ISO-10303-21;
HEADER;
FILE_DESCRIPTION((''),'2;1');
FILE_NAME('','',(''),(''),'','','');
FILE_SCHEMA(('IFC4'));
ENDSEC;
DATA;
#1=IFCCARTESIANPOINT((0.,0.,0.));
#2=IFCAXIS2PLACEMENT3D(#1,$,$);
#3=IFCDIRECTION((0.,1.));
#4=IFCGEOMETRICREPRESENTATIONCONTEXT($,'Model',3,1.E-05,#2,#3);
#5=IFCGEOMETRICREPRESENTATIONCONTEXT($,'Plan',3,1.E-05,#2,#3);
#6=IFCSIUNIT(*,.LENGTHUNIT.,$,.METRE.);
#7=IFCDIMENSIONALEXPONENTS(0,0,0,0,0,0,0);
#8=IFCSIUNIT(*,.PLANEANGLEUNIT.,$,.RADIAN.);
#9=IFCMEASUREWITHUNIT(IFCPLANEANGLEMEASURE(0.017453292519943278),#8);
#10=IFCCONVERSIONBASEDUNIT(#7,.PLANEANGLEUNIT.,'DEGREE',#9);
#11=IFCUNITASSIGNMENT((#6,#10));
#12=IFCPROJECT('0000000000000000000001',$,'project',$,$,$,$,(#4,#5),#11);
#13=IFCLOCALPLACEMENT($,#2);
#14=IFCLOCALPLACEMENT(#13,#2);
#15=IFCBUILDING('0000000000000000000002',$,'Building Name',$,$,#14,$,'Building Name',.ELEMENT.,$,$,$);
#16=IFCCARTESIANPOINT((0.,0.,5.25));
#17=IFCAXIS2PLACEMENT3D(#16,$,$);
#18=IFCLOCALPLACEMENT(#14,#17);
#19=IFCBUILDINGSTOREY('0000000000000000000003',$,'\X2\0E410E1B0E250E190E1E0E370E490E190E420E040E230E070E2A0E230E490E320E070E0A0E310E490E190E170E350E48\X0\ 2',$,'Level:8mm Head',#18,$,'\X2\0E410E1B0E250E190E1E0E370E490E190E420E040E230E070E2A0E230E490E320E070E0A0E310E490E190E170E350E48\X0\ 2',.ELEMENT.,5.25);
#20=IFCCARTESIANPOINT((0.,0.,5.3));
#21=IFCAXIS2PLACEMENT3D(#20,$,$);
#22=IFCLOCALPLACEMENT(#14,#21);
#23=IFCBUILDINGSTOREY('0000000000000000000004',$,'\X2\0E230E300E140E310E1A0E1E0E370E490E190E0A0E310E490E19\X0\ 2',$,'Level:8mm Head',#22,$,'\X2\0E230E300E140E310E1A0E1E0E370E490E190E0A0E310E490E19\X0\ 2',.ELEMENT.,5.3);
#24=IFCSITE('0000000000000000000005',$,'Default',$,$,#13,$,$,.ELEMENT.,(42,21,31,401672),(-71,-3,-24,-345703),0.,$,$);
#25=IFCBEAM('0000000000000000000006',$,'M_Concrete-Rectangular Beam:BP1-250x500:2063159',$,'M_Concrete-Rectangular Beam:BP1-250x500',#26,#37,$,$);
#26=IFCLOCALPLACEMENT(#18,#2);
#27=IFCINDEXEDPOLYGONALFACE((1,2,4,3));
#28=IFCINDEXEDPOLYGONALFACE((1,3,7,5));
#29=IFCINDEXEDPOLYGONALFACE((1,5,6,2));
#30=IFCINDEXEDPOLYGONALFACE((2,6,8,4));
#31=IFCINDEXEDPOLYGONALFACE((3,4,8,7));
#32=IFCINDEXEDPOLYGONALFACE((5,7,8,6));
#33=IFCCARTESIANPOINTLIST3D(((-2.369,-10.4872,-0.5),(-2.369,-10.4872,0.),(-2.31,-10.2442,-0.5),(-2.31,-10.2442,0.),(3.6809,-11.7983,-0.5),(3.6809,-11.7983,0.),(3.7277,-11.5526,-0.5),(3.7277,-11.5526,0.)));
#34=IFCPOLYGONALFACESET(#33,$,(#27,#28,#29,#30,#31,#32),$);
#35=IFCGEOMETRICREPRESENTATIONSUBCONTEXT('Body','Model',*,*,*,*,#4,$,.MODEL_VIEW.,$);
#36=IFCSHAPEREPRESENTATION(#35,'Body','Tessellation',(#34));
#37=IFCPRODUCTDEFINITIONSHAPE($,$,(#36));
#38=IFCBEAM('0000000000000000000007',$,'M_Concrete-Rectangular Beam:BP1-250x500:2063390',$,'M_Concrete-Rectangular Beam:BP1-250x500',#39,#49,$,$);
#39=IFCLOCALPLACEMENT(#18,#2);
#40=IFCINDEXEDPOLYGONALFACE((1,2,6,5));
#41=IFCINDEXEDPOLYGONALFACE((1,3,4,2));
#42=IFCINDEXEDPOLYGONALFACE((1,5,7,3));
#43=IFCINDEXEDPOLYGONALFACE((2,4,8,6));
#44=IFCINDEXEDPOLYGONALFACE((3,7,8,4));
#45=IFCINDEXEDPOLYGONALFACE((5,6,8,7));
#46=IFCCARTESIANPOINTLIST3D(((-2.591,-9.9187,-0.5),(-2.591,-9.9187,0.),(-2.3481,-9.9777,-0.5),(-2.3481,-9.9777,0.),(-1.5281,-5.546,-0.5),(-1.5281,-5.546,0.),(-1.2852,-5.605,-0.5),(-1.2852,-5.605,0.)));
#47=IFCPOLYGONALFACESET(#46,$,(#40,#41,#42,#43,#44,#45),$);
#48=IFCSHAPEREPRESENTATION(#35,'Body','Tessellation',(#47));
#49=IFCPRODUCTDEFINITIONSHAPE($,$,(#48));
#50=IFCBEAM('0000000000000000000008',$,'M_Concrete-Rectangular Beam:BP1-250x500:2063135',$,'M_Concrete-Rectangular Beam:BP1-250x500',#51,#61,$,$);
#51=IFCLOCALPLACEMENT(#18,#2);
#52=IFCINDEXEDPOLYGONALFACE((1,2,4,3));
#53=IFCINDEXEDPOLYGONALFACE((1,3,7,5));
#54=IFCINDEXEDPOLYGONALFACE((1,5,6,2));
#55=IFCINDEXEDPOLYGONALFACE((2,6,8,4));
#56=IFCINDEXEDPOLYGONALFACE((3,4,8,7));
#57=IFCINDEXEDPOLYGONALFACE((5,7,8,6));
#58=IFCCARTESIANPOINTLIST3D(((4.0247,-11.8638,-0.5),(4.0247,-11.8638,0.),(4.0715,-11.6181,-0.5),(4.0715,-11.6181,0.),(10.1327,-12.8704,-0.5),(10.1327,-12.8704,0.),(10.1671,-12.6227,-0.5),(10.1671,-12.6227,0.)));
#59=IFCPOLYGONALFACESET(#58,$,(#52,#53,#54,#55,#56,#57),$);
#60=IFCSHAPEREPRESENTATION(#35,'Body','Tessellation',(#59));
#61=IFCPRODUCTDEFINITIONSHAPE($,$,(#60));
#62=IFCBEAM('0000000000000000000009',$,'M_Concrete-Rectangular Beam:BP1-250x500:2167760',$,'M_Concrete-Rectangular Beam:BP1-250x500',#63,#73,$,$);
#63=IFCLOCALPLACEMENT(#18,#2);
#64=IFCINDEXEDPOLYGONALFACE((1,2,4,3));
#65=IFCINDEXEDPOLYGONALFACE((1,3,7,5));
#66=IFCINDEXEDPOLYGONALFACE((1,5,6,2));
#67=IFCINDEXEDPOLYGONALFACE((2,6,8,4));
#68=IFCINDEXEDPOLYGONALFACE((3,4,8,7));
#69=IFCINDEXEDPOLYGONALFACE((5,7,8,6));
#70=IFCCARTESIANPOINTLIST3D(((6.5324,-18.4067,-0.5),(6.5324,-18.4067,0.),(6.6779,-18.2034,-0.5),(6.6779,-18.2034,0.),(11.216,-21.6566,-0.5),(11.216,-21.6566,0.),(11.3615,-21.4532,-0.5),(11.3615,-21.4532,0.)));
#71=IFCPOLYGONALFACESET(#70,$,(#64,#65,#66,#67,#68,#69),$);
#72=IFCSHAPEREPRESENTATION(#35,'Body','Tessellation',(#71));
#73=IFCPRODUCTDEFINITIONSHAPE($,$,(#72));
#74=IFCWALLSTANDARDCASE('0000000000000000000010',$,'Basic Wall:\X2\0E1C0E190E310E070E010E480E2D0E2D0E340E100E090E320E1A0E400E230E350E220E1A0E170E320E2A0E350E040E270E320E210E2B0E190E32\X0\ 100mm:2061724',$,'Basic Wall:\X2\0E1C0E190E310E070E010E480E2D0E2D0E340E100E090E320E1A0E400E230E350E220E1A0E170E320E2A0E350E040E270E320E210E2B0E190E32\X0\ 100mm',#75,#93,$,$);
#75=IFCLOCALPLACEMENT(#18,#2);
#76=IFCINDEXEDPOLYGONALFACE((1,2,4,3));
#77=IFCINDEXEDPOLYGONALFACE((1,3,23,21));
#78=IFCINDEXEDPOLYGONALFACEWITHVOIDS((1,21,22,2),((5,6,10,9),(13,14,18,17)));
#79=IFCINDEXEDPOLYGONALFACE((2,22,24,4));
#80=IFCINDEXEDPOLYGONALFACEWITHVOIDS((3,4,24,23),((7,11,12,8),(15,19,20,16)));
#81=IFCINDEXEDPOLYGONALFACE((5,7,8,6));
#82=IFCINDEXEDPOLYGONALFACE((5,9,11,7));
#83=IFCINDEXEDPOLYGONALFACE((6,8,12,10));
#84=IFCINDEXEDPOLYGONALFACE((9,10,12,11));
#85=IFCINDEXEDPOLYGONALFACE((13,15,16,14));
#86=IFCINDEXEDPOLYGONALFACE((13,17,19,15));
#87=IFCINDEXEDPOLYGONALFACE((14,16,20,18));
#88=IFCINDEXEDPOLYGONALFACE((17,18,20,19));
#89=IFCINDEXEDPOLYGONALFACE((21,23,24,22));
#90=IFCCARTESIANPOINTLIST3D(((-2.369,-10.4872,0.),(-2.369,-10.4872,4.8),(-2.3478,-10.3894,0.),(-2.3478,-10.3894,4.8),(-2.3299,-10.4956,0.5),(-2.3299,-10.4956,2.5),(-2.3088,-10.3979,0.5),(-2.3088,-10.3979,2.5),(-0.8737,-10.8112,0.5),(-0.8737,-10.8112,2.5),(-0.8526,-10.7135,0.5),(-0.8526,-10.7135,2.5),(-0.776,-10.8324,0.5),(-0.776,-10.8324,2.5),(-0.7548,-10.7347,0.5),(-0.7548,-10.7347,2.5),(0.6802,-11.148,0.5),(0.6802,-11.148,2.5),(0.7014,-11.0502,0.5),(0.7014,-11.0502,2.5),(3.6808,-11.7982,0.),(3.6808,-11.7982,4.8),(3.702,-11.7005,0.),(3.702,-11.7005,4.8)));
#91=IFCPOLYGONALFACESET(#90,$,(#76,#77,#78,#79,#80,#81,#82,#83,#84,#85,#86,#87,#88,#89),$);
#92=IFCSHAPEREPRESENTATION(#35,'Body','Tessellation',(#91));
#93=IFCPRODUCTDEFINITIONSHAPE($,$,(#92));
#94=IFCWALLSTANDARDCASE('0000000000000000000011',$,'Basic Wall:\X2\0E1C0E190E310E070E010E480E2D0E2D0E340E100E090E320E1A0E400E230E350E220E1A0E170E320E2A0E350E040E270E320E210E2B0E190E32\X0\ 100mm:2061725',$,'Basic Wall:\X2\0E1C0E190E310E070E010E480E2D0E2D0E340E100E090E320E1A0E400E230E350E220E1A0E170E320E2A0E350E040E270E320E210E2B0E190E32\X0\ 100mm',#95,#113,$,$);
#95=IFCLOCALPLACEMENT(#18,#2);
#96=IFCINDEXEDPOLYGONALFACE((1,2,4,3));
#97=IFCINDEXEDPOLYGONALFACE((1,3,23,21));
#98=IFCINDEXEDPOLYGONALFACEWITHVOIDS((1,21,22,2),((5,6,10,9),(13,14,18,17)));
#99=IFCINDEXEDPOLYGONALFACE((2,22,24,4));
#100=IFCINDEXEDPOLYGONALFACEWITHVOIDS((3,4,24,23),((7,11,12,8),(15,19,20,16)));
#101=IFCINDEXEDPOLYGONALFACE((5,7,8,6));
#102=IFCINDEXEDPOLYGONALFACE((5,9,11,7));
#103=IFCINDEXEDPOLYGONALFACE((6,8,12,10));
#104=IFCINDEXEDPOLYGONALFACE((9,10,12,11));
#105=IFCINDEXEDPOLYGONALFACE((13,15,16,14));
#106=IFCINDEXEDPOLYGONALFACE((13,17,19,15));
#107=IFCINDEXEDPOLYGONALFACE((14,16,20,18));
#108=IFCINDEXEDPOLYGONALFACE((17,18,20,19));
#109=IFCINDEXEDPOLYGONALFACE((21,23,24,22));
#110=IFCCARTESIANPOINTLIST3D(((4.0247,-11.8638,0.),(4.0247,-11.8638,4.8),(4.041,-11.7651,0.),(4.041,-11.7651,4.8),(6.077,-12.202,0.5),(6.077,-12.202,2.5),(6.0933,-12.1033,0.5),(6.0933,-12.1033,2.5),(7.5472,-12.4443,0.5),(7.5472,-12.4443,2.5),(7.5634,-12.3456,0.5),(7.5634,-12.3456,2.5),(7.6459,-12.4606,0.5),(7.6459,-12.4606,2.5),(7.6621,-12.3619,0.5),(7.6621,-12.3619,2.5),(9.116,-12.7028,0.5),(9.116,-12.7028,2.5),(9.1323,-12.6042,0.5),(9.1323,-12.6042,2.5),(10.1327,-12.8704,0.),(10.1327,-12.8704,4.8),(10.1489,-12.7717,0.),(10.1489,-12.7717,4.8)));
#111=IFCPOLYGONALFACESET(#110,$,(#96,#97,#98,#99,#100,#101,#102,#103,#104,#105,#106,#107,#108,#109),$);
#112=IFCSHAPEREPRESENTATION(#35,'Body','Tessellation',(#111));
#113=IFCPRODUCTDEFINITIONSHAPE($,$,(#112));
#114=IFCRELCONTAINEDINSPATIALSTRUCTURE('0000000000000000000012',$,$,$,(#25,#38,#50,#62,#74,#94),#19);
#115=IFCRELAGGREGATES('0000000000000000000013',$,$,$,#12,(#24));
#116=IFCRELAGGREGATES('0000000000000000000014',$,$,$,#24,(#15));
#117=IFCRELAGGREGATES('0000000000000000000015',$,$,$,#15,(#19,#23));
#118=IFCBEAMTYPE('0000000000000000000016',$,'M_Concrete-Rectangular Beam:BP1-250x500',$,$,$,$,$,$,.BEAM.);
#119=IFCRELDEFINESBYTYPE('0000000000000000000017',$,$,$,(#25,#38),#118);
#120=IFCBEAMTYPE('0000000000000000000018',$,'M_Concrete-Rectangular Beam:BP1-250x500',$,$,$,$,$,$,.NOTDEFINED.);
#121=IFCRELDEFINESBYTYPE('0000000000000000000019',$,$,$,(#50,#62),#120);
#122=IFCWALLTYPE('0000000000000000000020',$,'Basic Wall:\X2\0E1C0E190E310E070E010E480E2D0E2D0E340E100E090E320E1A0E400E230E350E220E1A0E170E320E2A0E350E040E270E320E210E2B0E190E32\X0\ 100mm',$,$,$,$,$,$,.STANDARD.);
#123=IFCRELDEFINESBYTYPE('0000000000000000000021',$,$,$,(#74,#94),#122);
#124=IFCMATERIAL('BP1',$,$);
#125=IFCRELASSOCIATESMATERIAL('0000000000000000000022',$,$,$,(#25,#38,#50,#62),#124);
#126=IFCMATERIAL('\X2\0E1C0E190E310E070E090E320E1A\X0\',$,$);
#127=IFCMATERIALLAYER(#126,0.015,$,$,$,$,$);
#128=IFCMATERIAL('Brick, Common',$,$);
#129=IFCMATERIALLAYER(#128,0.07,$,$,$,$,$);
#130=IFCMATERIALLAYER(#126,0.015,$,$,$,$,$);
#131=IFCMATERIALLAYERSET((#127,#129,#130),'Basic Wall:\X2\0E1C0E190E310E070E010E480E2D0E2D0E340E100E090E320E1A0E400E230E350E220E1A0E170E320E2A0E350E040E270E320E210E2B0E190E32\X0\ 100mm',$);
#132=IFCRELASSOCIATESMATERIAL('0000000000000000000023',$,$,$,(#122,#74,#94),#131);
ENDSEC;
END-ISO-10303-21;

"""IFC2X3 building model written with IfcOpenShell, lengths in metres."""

from ifc_helpers import new_model, entity, si_unit, converted_unit, direction, frame, frame_2d, origin, place, context, subcontext, project, spatial, rectangle, extrude, clip, halfspace, material, layer, layer_set, layer_usage, type_object, element, save


model = new_model("IFC2X3")

# Units and contexts
model_context = context("Model", 3, precision=1e-05, world=origin(), true_north=direction((0.0, 1.0)))
plan_context = context("Plan", 3, precision=1e-05, world=origin(), true_north=direction((0.0, 1.0)))
body_context = subcontext(model_context, "Body", "Model", "MODEL_VIEW")
ifc_project = project(units=[si_unit("LENGTHUNIT", "METRE"), converted_unit("PLANEANGLEUNIT", "DEGREE", entity("IfcPlaneAngleMeasure", 0.017453292519943278), si_unit("PLANEANGLEUNIT", "RADIAN"), dimensions=[0, 0, 0, 0, 0, 0, 0])], contexts=[model_context, plan_context])

# Site, building, storey
site_placement = place(None, origin())
site = spatial("IfcSite", under=ifc_project, at=site_placement, Name="Default", CompositionType="ELEMENT", RefLatitude=(42, 21, 31, 401672), RefLongitude=(-71, -3, -24, -345703), RefElevation=0.0)
building_placement = place(site_placement, origin())
building = spatial("IfcBuilding", under=site, at=building_placement, Name="Building Name", LongName="Building Name", CompositionType="ELEMENT")
storey_1_placement = place(building_placement, frame((0.0, 0.0, 5.25)))
storey_1 = spatial("IfcBuildingStorey", under=building, at=storey_1_placement, Name="แปลนพื้นโครงสร้างชั้นที่ 2", ObjectType="Level:8mm Head", LongName="แปลนพื้นโครงสร้างชั้นที่ 2", CompositionType="ELEMENT", Elevation=5.25)

# Beams
ifc_material_1 = material(Name="BP1")
beam_type_1 = type_object("IfcBeamType", Name="M_Concrete-Rectangular Beam:BP1-250x500", PredefinedType="BEAM")
beam_1_placement = place(storey_1_placement, frame((3.6809, -11.7983, 0.0), z_axis=(0.0, 0.0, 1.0), x_axis=(-0.977314, 0.211795, 0.0)))
element("IfcBeam", 1, at=beam_1_placement, inside=storey_1, type_object=beam_type_1, material=ifc_material_1, Name="M_Concrete-Rectangular Beam:BP1-250x500:2063159", ObjectType="M_Concrete-Rectangular Beam:BP1-250x500", context=body_context, shape_type="Clipping", body=[
    clip(clip(extrude(rectangle(XDim=0.5, YDim=0.25, at=frame_2d((0.0, 0.0), x_axis=(1.0, 0.0))), frame((0.0, -0.125, -0.25), z_axis=(1.0, 0.0, 0.0), x_axis=(0.0, 0.0, -1.0)), (0.0, 0.0, 1.0), 6.1903), halfspace(frame((6.1903, 0.0, 0.0), z_axis=(0.999686, -0.02504, 0.0), x_axis=(0.0, 0.0, -1.0)), False)), halfspace(frame((0.0125, -0.4998, 0.0), z_axis=(-0.999686, -0.02504, 0.0), x_axis=(0.0, 0.0, -1.0)), False)),
])
beam_2_placement = place(storey_1_placement, frame((-2.591, -9.9187, 0.0), z_axis=(0.0, 0.0, 1.0), x_axis=(0.236201, 0.971704, 0.0)))
element("IfcBeam", 2, at=beam_2_placement, inside=storey_1, type_object=beam_type_1, material=ifc_material_1, Name="M_Concrete-Rectangular Beam:BP1-250x500:2063390", ObjectType="M_Concrete-Rectangular Beam:BP1-250x500", context=body_context, shape_type="SweptSolid", body=[
    extrude(rectangle(XDim=0.5, YDim=0.25, at=frame_2d((0.0, 0.0), x_axis=(1.0, 0.0))), frame((0.0, -0.125, -0.25), z_axis=(1.0, 0.0, 0.0), x_axis=(0.0, 0.0, -1.0)), (0.0, 0.0, 1.0), 4.5),
])
beam_type_2 = type_object("IfcBeamType", Name="M_Concrete-Rectangular Beam:BP1-250x500", PredefinedType="NOTDEFINED")
beam_3_placement = place(storey_1_placement, frame((10.1327, -12.8704, 0.0), z_axis=(0.0, 0.0, 1.0), x_axis=(-0.986692, 0.162602, 0.0)))
element("IfcBeam", 3, at=beam_3_placement, inside=storey_1, type_object=beam_type_2, material=ifc_material_1, Name="M_Concrete-Rectangular Beam:BP1-250x500:2063135", ObjectType="M_Concrete-Rectangular Beam:BP1-250x500", context=body_context, shape_type="Clipping", body=[
    clip(clip(extrude(rectangle(XDim=0.5, YDim=0.25, at=frame_2d((0.0, 0.0), x_axis=(1.0, 0.0))), frame((0.0, -0.125, -0.25), z_axis=(1.0, 0.0, 0.0), x_axis=(0.0, 0.0, -1.0)), (0.0, 0.0, 1.0), 6.1903), halfspace(frame((6.1903, 0.0, 0.0), z_axis=(0.999686, -0.02504, 0.0), x_axis=(0.0, 0.0, -1.0)), False)), halfspace(frame((0.0125, -0.4998, 0.0), z_axis=(-0.999686, -0.02504, 0.0), x_axis=(0.0, 0.0, -1.0)), False)),
])
beam_4_placement = place(storey_1_placement, frame((11.216, -21.6566, 0.0), z_axis=(0.0, 0.0, 1.0), x_axis=(-0.821587, 0.570084, 0.0)))
element("IfcBeam", 4, at=beam_4_placement, inside=storey_1, type_object=beam_type_2, material=ifc_material_1, Name="M_Concrete-Rectangular Beam:BP1-250x500:2167760", ObjectType="M_Concrete-Rectangular Beam:BP1-250x500", context=body_context, shape_type="Clipping", body=[
    clip(clip(extrude(rectangle(XDim=0.5, YDim=0.25, at=frame_2d((0.0, 0.0), x_axis=(1.0, 0.0))), frame((-0.0036, -0.125, -0.25), z_axis=(1.0, 0.0, 0.0), x_axis=(0.0, 0.0, -1.0)), (0.0, 0.0, 1.0), 5.7042), halfspace(frame((5.7006, 0.0, 0.0), z_axis=(0.999896, -0.014411, 0.0), x_axis=(0.0, 0.0, -1.0)), False)), halfspace(frame((-0.0043, -0.3, 0.0), z_axis=(-0.999896, 0.014411, 0.0), x_axis=(0.0, 0.0, -1.0)), False)),
])

# Walls, openings
ifc_material_2 = material(Name="ผนังฉาบ")
ifc_layer_1 = layer(ifc_material_2, 0.015)
ifc_material_3 = material(Name="Brick, Common")
ifc_layer_2 = layer(ifc_material_3, 0.07)
ifc_layer_3 = layer(ifc_material_2, 0.015)
ifc_layer_set = layer_set([ifc_layer_1, ifc_layer_2, ifc_layer_3], Name="Basic Wall:ผนังก่ออิฐฉาบเรียบทาสีความหนา 100mm")
ifc_layer_usage_1 = layer_usage(ifc_layer_set, "AXIS2", "POSITIVE", -0.05)
wall_type = type_object("IfcWallType", Name="Basic Wall:ผนังก่ออิฐฉาบเรียบทาสีความหนา 100mm", PredefinedType="STANDARD", material=ifc_layer_set)
wall_1_placement = place(storey_1_placement, frame((-2.3584, -10.4383, 0.0), z_axis=(0.0, 0.0, 1.0), x_axis=(0.977314, -0.211795, 0.0)))
wall_1 = element("IfcWallStandardCase", 5, at=wall_1_placement, inside=storey_1, type_object=wall_type, material=ifc_layer_usage_1, Name="Basic Wall:ผนังก่ออิฐฉาบเรียบทาสีความหนา 100mm:2061724", ObjectType="Basic Wall:ผนังก่ออิฐฉาบเรียบทาสีความหนา 100mm", context=body_context, shape_type="SweptSolid", body=[
    extrude(rectangle(XDim=6.1902, YDim=0.1, at=frame_2d((3.0951, 0.0), x_axis=(-1.0, 0.0))), origin(), (0.0, 0.0, 1.0), 4.8),
])
opening_1_placement = place(wall_1_placement, frame((0.0941, 10.701, 0.05), z_axis=(0.0, 0.0, 1.0), x_axis=(0.977314, 0.211795, 0.0)))
element("IfcOpeningElement", 6, at=opening_1_placement, cuts=wall_1, ObjectType="Opening", context=body_context, shape_type="SweptSolid", body=[
    extrude(rectangle(XDim=2.0, YDim=1.49, at=frame_2d((0.0, 0.0), x_axis=(0.0, 1.0))), frame((-1.9034, -12.0451, 1.45), z_axis=(0.211795, 0.977314, 0.0), x_axis=(-0.977314, 0.211795, 0.0)), (0.0, 0.0, 1.0), 3.048),
])
opening_2_placement = place(wall_1_placement, frame((1.53, 0.05, 0.5)))
element("IfcOpeningElement", 7, at=opening_2_placement, cuts=wall_1, ObjectType="Opening", context=body_context, shape_type="SweptSolid", body=[
    extrude(rectangle(XDim=2.0, YDim=1.49, at=frame_2d((1.0, 0.745), x_axis=(1.0, 0.0))), frame((0.0, 0.0, 0.0), z_axis=(0.0, -1.0, 0.0), x_axis=(0.0, 0.0, 1.0)), (0.0, 0.0, 1.0), 0.1),
])
opening_3_placement = place(wall_1_placement, frame((0.0941, 10.701, 0.05), z_axis=(0.0, 0.0, 1.0), x_axis=(0.977314, 0.211795, 0.0)))
element("IfcOpeningElement", 8, at=opening_3_placement, cuts=wall_1, ObjectType="Opening", context=body_context, shape_type="SweptSolid", body=[
    extrude(rectangle(XDim=2.0, YDim=1.49, at=frame_2d((0.0, 0.0), x_axis=(0.0, 1.0))), frame((-0.3495, -12.3819, 1.45), z_axis=(0.211795, 0.977314, 0.0), x_axis=(-0.977314, 0.211795, 0.0)), (0.0, 0.0, 1.0), 3.048),
])
opening_4_placement = place(wall_1_placement, frame((3.12, 0.05, 0.5)))
element("IfcOpeningElement", 9, at=opening_4_placement, cuts=wall_1, ObjectType="Opening", context=body_context, shape_type="SweptSolid", body=[
    extrude(rectangle(XDim=2.0, YDim=1.49, at=frame_2d((1.0, 0.745), x_axis=(1.0, 0.0))), frame((0.0, 0.0, 0.0), z_axis=(0.0, -1.0, 0.0), x_axis=(0.0, 0.0, 1.0)), (0.0, 0.0, 1.0), 0.1),
])
ifc_layer_usage_2 = layer_usage(ifc_layer_set, "AXIS2", "POSITIVE", -0.05)
wall_2_placement = place(storey_1_placement, frame((4.0328, -11.8145, 0.0), z_axis=(0.0, 0.0, 1.0), x_axis=(0.986692, -0.162602, 0.0)))
wall_2 = element("IfcWallStandardCase", 10, at=wall_2_placement, inside=storey_1, type_object=wall_type, material=ifc_layer_usage_2, Name="Basic Wall:ผนังก่ออิฐฉาบเรียบทาสีความหนา 100mm:2061725", ObjectType="Basic Wall:ผนังก่ออิฐฉาบเรียบทาสีความหนา 100mm", context=body_context, shape_type="SweptSolid", body=[
    extrude(rectangle(XDim=6.1903, YDim=0.1, at=frame_2d((3.0952, 0.0), x_axis=(-1.0, 0.0))), origin(), (0.0, 0.0, 1.0), 4.8),
])
opening_5_placement = place(wall_2_placement, frame((-5.9002, 11.0015, 0.05), z_axis=(0.0, 0.0, 1.0), x_axis=(0.986692, 0.162602, 0.0)))
element("IfcOpeningElement", 11, at=opening_5_placement, cuts=wall_2, ObjectType="Opening", context=body_context, shape_type="SweptSolid", body=[
    extrude(rectangle(XDim=2.0, YDim=1.49, at=frame_2d((0.0, 0.0), x_axis=(0.0, 1.0))), frame((6.5806, -13.7282, 1.45), z_axis=(0.162602, 0.986692, 0.0), x_axis=(-0.986692, 0.162602, 0.0)), (0.0, 0.0, 1.0), 3.048),
])
opening_6_placement = place(wall_2_placement, frame((3.57, 0.05, 0.5)))
element("IfcOpeningElement", 12, at=opening_6_placement, cuts=wall_2, ObjectType="Opening", context=body_context, shape_type="SweptSolid", body=[
    extrude(rectangle(XDim=2.0, YDim=1.49, at=frame_2d((1.0, 0.745), x_axis=(1.0, 0.0))), frame((0.0, 0.0, 0.0), z_axis=(0.0, -1.0, 0.0), x_axis=(0.0, 0.0, 1.0)), (0.0, 0.0, 1.0), 0.1),
])
opening_7_placement = place(wall_2_placement, frame((-5.9002, 11.0015, 0.05), z_axis=(0.0, 0.0, 1.0), x_axis=(0.986692, 0.162602, 0.0)))
element("IfcOpeningElement", 13, at=opening_7_placement, cuts=wall_2, ObjectType="Opening", context=body_context, shape_type="SweptSolid", body=[
    extrude(rectangle(XDim=2.0, YDim=1.49, at=frame_2d((0.0, 0.0), x_axis=(0.0, 1.0))), frame((8.1494, -13.9867, 1.45), z_axis=(0.162602, 0.986692, 0.0), x_axis=(-0.986692, 0.162602, 0.0)), (0.0, 0.0, 1.0), 3.048),
])
opening_8_placement = place(wall_2_placement, frame((5.16, 0.05, 0.5)))
element("IfcOpeningElement", 14, at=opening_8_placement, cuts=wall_2, ObjectType="Opening", context=body_context, shape_type="SweptSolid", body=[
    extrude(rectangle(XDim=2.0, YDim=1.49, at=frame_2d((1.0, 0.745), x_axis=(1.0, 0.0))), frame((0.0, 0.0, 0.0), z_axis=(0.0, -1.0, 0.0), x_axis=(0.0, 0.0, 1.0)), (0.0, 0.0, 1.0), 0.1),
])

# Shared definitions
storey_2_placement = place(building_placement, frame((0.0, 0.0, 5.3)))
storey_2 = spatial("IfcBuildingStorey", under=building, at=storey_2_placement, Name="ระดับพื้นชั้น 2", ObjectType="Level:8mm Head", LongName="ระดับพื้นชั้น 2", CompositionType="ELEMENT", Elevation=5.3)

save(model, "model.ifc")
